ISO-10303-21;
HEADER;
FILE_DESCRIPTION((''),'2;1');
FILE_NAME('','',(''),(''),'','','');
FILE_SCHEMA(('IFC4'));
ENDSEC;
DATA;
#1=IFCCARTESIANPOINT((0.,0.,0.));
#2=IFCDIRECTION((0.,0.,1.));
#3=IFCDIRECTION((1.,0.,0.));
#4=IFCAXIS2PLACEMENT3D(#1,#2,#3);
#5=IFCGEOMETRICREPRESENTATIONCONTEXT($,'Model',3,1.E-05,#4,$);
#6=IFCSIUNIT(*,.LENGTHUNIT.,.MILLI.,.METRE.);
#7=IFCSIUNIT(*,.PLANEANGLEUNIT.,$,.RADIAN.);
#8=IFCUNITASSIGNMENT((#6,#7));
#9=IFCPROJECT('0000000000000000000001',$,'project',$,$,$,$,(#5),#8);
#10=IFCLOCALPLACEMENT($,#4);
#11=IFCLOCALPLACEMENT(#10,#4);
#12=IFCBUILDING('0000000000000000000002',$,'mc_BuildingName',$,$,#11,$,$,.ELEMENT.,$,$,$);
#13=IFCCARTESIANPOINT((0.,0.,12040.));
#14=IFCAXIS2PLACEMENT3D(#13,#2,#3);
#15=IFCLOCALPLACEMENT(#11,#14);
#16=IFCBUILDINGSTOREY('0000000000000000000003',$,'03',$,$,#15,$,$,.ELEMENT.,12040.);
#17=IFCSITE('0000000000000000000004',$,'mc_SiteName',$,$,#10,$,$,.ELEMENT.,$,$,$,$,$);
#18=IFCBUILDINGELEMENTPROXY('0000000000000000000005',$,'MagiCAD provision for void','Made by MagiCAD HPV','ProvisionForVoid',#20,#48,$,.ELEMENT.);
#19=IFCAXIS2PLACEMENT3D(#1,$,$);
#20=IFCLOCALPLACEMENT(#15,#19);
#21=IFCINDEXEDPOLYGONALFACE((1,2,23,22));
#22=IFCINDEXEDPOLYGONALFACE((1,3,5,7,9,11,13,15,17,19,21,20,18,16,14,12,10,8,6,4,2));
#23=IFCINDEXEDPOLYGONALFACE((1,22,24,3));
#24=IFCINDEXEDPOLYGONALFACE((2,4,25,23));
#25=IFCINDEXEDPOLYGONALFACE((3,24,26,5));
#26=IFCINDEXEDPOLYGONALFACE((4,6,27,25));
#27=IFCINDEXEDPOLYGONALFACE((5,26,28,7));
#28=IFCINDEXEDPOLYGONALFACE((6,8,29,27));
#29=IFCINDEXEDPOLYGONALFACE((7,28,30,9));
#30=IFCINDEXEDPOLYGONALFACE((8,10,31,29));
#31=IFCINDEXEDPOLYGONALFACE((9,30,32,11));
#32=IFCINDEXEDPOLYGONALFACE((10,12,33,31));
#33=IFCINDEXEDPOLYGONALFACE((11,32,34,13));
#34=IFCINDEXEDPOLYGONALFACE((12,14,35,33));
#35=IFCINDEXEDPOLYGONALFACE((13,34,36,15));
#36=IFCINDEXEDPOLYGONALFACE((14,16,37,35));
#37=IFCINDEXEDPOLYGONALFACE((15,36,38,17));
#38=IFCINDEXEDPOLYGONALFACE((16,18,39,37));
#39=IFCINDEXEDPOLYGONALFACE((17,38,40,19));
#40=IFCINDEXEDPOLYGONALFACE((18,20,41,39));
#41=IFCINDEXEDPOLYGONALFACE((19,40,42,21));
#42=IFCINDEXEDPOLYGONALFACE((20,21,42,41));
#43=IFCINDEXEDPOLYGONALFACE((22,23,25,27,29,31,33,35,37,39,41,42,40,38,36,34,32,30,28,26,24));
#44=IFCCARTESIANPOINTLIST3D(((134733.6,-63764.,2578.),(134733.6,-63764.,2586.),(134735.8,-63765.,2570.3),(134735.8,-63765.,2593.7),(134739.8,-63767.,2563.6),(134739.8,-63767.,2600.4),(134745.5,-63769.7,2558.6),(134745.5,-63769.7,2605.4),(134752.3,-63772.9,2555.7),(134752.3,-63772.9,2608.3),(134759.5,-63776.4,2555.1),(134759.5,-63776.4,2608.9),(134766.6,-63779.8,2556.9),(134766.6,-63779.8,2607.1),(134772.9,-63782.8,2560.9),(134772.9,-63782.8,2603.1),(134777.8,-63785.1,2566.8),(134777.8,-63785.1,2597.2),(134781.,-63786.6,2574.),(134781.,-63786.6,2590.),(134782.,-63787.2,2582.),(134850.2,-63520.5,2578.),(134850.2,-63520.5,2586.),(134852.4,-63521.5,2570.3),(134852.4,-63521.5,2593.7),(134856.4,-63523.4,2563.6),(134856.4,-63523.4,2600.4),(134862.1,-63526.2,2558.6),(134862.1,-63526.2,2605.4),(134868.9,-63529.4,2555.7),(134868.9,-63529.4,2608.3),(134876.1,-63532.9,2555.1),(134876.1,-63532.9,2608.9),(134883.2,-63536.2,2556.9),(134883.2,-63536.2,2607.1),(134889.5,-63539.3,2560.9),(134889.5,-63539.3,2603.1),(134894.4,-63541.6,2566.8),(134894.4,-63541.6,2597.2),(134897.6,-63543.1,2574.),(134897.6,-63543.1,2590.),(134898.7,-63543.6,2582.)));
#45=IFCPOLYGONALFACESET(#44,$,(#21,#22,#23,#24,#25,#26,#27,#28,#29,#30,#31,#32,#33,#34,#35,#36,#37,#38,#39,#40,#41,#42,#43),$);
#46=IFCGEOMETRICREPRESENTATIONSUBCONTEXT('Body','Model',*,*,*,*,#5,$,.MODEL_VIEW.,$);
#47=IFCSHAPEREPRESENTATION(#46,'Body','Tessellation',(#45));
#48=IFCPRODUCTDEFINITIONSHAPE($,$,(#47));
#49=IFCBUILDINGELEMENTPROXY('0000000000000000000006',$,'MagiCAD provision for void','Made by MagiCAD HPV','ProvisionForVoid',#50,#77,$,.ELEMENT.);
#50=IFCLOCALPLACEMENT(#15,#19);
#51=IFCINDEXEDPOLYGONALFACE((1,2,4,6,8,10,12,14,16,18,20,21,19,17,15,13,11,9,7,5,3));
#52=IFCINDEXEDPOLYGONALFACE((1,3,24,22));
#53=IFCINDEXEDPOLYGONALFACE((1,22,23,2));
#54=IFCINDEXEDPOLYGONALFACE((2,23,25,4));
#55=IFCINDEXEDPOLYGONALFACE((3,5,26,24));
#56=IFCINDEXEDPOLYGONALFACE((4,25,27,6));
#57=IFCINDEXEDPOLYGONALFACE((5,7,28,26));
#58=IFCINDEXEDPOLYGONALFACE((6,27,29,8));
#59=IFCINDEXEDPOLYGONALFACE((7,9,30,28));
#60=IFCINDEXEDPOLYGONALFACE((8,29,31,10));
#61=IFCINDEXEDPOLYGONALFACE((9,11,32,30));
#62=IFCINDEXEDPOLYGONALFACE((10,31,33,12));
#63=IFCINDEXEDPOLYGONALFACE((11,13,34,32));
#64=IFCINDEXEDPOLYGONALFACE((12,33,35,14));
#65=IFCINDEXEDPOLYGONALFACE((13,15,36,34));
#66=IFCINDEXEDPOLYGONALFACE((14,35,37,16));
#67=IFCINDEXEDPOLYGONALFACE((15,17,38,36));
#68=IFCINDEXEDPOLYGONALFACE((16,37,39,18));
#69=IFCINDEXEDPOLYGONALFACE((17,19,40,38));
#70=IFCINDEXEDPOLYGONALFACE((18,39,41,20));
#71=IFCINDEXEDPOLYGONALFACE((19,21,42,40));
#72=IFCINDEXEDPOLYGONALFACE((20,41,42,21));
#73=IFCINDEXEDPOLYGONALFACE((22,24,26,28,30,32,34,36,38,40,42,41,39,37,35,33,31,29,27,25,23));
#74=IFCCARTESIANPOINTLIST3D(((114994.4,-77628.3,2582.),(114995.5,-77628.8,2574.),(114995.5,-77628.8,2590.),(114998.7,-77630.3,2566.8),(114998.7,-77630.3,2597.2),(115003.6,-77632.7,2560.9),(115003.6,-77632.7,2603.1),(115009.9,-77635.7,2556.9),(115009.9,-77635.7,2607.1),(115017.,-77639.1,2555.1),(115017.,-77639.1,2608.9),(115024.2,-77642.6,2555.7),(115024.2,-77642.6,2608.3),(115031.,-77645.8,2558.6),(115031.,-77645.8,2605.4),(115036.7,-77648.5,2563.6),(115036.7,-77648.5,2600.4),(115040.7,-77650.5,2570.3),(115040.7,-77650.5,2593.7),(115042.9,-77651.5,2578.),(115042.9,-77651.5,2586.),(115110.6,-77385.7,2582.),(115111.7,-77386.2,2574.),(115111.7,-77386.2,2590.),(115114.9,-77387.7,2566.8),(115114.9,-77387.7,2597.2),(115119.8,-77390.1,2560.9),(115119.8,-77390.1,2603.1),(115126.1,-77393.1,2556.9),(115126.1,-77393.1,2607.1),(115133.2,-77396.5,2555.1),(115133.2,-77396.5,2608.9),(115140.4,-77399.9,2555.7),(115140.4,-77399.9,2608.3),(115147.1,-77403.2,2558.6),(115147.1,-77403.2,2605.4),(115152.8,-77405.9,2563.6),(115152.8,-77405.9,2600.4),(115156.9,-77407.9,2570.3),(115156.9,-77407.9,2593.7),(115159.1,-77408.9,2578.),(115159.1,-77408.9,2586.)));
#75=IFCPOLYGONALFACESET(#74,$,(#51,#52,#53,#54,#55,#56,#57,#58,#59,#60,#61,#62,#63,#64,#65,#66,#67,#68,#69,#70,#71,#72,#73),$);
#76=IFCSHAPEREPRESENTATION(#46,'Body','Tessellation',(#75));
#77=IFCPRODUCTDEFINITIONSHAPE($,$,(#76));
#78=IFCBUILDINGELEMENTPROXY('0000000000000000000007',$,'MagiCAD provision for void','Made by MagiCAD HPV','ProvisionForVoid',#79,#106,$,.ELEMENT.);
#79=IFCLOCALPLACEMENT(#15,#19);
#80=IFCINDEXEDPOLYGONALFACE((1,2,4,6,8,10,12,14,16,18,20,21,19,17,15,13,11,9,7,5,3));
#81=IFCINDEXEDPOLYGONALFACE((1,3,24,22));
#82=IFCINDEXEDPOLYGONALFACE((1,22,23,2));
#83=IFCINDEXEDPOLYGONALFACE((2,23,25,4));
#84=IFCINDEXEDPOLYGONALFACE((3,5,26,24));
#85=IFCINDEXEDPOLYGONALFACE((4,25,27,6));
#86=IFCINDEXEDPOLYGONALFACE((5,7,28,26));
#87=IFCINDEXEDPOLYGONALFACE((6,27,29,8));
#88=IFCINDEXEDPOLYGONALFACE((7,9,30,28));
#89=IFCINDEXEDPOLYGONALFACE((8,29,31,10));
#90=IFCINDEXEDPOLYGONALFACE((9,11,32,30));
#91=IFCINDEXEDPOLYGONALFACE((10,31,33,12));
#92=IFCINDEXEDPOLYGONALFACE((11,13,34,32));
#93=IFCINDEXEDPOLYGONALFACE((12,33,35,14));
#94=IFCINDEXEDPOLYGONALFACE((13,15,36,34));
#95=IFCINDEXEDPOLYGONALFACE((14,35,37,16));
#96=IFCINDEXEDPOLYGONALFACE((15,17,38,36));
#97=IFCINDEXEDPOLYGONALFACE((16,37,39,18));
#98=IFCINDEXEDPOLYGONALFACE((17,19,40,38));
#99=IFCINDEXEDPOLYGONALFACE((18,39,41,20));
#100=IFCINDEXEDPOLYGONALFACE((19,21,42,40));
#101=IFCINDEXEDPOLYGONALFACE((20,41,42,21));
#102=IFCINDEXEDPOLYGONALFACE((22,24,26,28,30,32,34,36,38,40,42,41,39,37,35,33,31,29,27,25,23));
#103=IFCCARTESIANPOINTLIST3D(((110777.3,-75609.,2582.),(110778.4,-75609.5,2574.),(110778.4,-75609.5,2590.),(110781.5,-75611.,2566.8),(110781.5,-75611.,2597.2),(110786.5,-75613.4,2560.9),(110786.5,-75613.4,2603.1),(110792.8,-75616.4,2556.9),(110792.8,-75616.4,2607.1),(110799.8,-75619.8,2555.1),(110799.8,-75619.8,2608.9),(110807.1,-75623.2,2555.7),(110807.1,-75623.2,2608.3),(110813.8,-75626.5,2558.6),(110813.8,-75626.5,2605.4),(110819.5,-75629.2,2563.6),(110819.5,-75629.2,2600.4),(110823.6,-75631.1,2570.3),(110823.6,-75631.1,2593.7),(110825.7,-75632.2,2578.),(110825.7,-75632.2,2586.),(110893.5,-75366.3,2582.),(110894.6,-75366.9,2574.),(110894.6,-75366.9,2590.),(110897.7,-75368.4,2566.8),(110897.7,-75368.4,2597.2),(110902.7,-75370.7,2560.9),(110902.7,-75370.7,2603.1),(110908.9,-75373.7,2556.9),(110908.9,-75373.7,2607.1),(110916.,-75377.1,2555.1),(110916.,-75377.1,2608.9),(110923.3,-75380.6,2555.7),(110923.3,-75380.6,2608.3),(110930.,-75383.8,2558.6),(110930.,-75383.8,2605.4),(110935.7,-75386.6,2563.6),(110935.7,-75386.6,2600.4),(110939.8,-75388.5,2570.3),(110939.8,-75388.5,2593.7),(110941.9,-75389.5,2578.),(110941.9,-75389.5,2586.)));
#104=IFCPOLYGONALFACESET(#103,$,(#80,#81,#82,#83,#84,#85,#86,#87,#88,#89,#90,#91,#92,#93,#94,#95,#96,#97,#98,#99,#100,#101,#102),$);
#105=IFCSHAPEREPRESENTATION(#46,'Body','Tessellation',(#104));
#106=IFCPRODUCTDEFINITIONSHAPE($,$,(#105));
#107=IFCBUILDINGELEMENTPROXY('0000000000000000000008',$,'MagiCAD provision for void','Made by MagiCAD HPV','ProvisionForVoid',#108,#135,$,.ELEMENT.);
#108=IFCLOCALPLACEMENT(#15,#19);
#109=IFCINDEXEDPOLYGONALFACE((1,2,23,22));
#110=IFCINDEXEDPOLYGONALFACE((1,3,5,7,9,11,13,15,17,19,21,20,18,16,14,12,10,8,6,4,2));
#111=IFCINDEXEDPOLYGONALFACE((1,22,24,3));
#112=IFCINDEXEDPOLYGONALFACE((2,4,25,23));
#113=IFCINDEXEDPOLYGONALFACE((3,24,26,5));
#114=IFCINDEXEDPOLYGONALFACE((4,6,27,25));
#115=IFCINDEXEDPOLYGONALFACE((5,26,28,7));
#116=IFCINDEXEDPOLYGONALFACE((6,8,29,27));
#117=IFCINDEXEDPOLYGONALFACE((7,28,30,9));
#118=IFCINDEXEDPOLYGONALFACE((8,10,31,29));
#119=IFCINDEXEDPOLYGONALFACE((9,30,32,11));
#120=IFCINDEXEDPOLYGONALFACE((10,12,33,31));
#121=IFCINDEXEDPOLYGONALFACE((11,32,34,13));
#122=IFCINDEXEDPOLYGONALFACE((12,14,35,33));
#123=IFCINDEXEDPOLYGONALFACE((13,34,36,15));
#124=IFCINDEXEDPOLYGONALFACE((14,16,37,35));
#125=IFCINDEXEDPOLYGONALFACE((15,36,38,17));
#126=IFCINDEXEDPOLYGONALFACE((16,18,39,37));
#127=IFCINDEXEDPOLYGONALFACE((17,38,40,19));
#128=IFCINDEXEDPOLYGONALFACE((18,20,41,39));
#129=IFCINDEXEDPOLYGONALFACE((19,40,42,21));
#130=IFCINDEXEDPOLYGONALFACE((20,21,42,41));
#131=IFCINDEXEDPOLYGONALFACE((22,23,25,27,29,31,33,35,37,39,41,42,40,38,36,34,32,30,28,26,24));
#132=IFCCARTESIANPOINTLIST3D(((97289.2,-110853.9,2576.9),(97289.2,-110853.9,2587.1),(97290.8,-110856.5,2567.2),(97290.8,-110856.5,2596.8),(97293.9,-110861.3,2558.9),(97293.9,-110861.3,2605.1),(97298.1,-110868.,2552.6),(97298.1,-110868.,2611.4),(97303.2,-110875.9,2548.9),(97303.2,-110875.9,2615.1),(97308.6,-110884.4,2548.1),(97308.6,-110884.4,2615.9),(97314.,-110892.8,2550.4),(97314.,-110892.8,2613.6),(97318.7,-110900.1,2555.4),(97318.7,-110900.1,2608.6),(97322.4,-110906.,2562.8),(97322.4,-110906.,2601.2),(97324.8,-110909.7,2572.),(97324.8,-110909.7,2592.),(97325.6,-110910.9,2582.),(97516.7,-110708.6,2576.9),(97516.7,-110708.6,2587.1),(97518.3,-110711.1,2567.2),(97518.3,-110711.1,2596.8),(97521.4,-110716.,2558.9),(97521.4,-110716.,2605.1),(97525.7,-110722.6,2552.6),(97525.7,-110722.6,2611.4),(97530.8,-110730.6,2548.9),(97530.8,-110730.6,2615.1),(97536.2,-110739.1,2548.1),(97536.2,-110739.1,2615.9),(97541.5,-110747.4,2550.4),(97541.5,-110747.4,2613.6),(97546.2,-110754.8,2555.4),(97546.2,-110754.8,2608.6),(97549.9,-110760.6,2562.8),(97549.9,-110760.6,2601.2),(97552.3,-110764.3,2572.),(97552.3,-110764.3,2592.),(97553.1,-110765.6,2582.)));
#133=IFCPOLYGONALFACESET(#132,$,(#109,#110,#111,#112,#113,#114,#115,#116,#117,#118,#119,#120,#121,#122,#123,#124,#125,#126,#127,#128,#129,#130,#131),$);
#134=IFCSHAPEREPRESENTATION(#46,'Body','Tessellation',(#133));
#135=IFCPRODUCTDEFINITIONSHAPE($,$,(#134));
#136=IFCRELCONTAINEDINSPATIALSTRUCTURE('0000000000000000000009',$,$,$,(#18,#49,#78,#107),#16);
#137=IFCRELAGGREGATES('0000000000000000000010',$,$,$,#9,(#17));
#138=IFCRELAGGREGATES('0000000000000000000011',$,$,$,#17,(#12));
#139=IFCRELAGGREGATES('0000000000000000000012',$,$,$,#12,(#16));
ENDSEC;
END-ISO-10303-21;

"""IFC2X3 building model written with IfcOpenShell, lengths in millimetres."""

from ifc_helpers import new_model, si_unit, frame, origin_with_axes, origin_2d_with_axis, place, context, subcontext, project, spatial, circle, extrude, source, transform, mapped, element, save


model = new_model("IFC2X3")

# Units and contexts
model_context = context("Model", 3, precision=1e-05, world=origin_with_axes())
body_context = subcontext(model_context, "Body", "Model", "MODEL_VIEW")
ifc_project = project(units=[si_unit("LENGTHUNIT", "METRE", prefix="MILLI"), si_unit("PLANEANGLEUNIT", "RADIAN")], contexts=[model_context])

# Site, building, storey
site_placement = place(None, origin_with_axes())
site = spatial("IfcSite", under=ifc_project, at=site_placement, Name="mc_SiteName", CompositionType="ELEMENT")
building_placement = place(site_placement, origin_with_axes())
building = spatial("IfcBuilding", under=site, at=building_placement, Name="mc_BuildingName", CompositionType="ELEMENT")
storey_placement = place(building_placement, frame((0.0, 0.0, 12040.0), z_axis=(0.0, 0.0, 1.0), x_axis=(1.0, 0.0, 0.0)))
storey = spatial("IfcBuildingStorey", under=building, at=storey_placement, Name="03", CompositionType="ELEMENT", Elevation=12040.0)

# Building element proxies
shared_shape_1 = source(origin_with_axes(), body_context, "Body", "SweptSolid", [
    extrude(circle(Radius=27.0, at=origin_2d_with_axis()), frame((0.0, 0.0, 0.0), z_axis=(1.0, 0.0, 0.0), x_axis=(0.0, 1.0, 0.0)), (0.0, 0.0, 1.0), 270.0),
])
proxy_1_placement = place(storey_placement, frame((134874.3, -63532.0, 2582.0), z_axis=(0.0, 0.0, 1.0), x_axis=(-0.431882, -0.90193, 0.0)))
element("IfcBuildingElementProxy", 1, at=proxy_1_placement, inside=storey, Name="MagiCAD provision for void", Description="Made by MagiCAD HPV", ObjectType="ProvisionForVoid", CompositionType="ELEMENT", context=body_context, shape_type="MappedRepresentation", body=[
    mapped(shared_shape_1, transform((0.0, 0.0, 0.0), scale=1.0)),
])
shared_shape_2 = source(origin_with_axes(), body_context, "Body", "SweptSolid", [
    extrude(circle(Radius=27.0, at=origin_2d_with_axis()), frame((0.0, 0.0, 0.0), z_axis=(1.0, 0.0, 0.0), x_axis=(0.0, 1.0, 0.0)), (0.0, 0.0, 1.0), 269.0),
])
proxy_2_placement = place(storey_placement, frame((115018.8, -77640.0, 2582.0), z_axis=(0.0, 0.0, 1.0), x_axis=(0.431859, 0.901941, 0.0)))
element("IfcBuildingElementProxy", 2, at=proxy_2_placement, inside=storey, Name="MagiCAD provision for void", Description="Made by MagiCAD HPV", ObjectType="ProvisionForVoid", CompositionType="ELEMENT", context=body_context, shape_type="MappedRepresentation", body=[
    mapped(shared_shape_2, transform((0.0, 0.0, 0.0), scale=1.0)),
])
shared_shape_3 = source(origin_with_axes(), body_context, "Body", "SweptSolid", [
    extrude(circle(Radius=27.0, at=origin_2d_with_axis()), frame((0.0, 0.0, 0.0), z_axis=(1.0, 0.0, 0.0), x_axis=(0.0, 1.0, 0.0)), (0.0, 0.0, 1.0), 269.0),
])
proxy_3_placement = place(storey_placement, frame((110801.7, -75620.6, 2582.0), z_axis=(0.0, 0.0, 1.0), x_axis=(0.431859, 0.901941, 0.0)))
element("IfcBuildingElementProxy", 3, at=proxy_3_placement, inside=storey, Name="MagiCAD provision for void", Description="Made by MagiCAD HPV", ObjectType="ProvisionForVoid", CompositionType="ELEMENT", context=body_context, shape_type="MappedRepresentation", body=[
    mapped(shared_shape_3, transform((0.0, 0.0, 0.0), scale=1.0)),
])
shared_shape_4 = source(origin_with_axes(), body_context, "Body", "SweptSolid", [
    extrude(circle(Radius=34.0, at=origin_2d_with_axis()), frame((0.0, 0.0, 0.0), z_axis=(1.0, 0.0, 0.0), x_axis=(0.0, 1.0, 0.0)), (0.0, 0.0, 1.0), 270.0),
])
proxy_4_placement = place(storey_placement, frame((97534.8, -110737.0, 2582.0), z_axis=(0.0, 0.0, 1.0), x_axis=(-0.842809, -0.538213, 0.0)))
element("IfcBuildingElementProxy", 4, at=proxy_4_placement, inside=storey, Name="MagiCAD provision for void", Description="Made by MagiCAD HPV", ObjectType="ProvisionForVoid", CompositionType="ELEMENT", context=body_context, shape_type="MappedRepresentation", body=[
    mapped(shared_shape_4, transform((0.0, 0.0, 0.0), scale=1.0)),
])

save(model, "model.ifc")
